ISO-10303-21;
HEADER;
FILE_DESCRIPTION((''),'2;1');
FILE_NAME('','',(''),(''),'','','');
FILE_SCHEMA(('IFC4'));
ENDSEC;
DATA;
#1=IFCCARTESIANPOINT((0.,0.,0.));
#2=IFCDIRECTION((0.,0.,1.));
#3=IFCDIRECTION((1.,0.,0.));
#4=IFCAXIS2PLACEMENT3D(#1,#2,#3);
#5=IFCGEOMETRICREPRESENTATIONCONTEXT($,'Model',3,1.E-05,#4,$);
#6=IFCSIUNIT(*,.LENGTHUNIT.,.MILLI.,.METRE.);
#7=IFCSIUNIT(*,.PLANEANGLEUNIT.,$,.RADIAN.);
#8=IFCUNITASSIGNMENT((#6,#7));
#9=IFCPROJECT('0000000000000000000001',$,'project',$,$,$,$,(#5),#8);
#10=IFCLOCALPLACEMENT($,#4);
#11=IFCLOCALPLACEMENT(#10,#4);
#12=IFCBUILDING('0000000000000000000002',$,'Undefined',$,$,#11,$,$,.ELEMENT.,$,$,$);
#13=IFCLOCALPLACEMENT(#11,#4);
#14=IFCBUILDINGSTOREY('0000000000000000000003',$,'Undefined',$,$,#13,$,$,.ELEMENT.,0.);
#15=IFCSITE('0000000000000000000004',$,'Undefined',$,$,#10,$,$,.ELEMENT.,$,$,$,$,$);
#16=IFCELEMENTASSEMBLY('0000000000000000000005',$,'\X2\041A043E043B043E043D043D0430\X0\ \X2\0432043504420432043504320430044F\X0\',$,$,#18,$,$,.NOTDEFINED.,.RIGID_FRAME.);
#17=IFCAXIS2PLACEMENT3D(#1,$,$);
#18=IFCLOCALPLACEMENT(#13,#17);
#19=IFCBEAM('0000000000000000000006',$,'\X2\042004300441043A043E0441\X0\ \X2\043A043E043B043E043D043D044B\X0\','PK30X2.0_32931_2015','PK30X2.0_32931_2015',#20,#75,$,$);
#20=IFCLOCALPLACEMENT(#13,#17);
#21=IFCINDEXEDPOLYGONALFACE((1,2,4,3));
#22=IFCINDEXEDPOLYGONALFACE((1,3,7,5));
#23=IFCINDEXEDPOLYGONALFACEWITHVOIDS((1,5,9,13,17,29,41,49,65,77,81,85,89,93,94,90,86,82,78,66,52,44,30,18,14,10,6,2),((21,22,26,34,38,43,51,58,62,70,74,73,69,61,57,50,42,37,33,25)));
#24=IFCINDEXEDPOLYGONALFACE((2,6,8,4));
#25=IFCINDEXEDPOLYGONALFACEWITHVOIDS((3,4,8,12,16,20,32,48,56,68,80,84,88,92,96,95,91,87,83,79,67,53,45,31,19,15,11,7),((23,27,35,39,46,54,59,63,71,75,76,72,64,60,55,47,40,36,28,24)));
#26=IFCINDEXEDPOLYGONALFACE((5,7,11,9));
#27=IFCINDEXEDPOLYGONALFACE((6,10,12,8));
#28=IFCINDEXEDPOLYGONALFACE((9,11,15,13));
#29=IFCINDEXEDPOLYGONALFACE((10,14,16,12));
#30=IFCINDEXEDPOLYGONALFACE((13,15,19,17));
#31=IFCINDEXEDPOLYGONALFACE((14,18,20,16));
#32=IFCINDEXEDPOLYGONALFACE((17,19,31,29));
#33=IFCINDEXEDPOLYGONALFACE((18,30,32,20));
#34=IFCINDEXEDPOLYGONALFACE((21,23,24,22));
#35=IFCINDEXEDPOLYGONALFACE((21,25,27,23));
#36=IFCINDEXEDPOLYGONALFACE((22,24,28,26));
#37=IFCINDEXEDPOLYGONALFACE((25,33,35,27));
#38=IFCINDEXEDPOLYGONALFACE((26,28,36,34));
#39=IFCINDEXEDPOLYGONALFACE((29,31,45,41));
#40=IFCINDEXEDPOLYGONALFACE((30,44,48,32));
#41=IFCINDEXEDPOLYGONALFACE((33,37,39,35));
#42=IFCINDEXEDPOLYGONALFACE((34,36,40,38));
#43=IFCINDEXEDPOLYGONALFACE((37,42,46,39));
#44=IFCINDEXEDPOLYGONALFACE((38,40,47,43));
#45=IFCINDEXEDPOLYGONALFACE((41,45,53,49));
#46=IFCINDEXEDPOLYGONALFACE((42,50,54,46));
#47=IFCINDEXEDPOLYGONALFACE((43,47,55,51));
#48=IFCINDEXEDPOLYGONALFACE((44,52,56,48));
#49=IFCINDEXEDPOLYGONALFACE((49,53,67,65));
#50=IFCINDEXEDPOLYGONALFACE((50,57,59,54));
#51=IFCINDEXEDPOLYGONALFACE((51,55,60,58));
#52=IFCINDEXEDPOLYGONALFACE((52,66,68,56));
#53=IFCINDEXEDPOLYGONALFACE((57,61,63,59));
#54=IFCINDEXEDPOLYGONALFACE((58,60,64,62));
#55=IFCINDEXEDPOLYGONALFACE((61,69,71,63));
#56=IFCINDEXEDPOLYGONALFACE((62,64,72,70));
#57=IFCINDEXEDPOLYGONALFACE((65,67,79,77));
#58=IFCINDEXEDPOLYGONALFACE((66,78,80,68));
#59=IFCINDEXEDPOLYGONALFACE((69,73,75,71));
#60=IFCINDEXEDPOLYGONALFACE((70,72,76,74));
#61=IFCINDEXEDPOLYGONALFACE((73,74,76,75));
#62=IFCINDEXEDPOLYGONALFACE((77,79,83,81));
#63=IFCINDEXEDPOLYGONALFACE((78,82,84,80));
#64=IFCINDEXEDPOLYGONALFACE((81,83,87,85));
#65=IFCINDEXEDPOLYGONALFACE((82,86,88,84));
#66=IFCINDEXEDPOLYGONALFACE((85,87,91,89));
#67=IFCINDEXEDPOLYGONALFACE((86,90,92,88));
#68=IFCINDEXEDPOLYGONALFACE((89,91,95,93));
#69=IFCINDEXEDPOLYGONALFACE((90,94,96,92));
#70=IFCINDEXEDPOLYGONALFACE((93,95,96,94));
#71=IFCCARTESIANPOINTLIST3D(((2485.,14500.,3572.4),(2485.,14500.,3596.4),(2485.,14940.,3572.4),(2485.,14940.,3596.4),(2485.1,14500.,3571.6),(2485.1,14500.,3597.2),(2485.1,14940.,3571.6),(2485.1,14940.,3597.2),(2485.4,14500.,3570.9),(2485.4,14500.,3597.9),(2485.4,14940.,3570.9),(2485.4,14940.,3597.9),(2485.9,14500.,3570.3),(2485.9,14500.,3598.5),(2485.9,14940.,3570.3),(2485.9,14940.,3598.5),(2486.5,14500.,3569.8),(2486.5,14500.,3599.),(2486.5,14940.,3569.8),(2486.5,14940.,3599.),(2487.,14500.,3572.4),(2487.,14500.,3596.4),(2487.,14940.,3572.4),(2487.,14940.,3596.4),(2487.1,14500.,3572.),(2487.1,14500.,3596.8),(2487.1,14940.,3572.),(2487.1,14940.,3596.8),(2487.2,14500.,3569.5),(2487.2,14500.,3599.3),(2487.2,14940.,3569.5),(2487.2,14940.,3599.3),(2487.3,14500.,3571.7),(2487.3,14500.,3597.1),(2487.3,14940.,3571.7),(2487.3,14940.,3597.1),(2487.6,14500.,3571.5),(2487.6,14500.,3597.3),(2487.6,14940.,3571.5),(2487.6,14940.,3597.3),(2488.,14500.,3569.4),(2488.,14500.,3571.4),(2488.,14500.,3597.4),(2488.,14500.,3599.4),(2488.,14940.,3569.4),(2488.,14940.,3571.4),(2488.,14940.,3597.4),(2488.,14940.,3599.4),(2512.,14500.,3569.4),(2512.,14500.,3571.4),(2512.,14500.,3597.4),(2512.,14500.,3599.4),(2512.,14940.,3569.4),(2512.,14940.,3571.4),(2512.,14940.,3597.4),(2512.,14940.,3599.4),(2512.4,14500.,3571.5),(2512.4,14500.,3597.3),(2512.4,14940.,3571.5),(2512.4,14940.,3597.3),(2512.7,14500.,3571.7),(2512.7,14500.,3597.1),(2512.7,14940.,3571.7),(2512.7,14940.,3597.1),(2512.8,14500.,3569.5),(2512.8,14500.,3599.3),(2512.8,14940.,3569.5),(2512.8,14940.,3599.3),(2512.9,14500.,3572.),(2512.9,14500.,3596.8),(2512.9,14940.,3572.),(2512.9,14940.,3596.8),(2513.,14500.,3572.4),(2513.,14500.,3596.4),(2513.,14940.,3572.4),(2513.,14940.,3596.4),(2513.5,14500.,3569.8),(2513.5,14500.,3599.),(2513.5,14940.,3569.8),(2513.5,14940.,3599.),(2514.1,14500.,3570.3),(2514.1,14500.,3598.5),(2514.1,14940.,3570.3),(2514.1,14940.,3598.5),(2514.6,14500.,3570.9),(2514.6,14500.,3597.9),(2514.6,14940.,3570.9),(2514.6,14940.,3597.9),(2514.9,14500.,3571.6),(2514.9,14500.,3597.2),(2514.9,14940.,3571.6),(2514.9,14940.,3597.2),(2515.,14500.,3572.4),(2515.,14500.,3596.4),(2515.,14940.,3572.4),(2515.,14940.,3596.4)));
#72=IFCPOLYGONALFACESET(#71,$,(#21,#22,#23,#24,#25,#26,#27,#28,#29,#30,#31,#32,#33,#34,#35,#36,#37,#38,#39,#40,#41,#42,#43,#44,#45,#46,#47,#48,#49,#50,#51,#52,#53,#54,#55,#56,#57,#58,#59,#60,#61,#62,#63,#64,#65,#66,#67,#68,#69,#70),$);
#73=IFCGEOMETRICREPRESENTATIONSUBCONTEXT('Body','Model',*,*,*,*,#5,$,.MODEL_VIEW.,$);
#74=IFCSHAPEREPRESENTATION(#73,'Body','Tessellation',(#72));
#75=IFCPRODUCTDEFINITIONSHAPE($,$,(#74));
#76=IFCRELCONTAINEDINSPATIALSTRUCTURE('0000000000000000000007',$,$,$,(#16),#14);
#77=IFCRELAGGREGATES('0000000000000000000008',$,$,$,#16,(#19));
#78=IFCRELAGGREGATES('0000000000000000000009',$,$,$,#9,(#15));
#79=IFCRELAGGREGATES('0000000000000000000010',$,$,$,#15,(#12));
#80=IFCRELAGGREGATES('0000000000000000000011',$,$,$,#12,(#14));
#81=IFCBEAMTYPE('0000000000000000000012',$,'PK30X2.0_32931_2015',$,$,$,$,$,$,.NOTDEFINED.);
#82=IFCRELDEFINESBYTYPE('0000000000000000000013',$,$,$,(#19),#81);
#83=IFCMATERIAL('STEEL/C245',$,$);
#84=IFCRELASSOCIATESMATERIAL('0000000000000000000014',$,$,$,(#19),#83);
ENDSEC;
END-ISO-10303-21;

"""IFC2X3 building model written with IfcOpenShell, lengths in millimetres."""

from ifc_helpers import new_model, si_unit, frame, origin_with_axes, origin_2d_with_axis, place, context, subcontext, project, spatial, hollow_rectangle, extrude, material, type_object, element, aggregate, save


model = new_model("IFC2X3")

# Units and contexts
model_context = context("Model", 3, precision=1e-05, world=origin_with_axes())
body_context = subcontext(model_context, "Body", "Model", "MODEL_VIEW")
ifc_project = project(units=[si_unit("LENGTHUNIT", "METRE", prefix="MILLI"), si_unit("PLANEANGLEUNIT", "RADIAN")], contexts=[model_context])

# Site, building, storey
site_placement = place(None, origin_with_axes())
site = spatial("IfcSite", under=ifc_project, at=site_placement, Name="Undefined", CompositionType="ELEMENT")
building_placement = place(site_placement, origin_with_axes())
building = spatial("IfcBuilding", under=site, at=building_placement, Name="Undefined", CompositionType="ELEMENT")
storey_placement = place(building_placement, origin_with_axes())
storey = spatial("IfcBuildingStorey", under=building, at=storey_placement, Name="Undefined", CompositionType="ELEMENT", Elevation=0.0)

# Shared definitions
ifc_material_1 = material(Name="STEEL/C245")

# Element assembly
assembly_1_placement = place(storey_placement, origin_with_axes())
assembly_1 = element("IfcElementAssembly", 1, at=assembly_1_placement, inside=storey, Name="Колонна ветвевая", AssemblyPlace="NOTDEFINED", PredefinedType="RIGID_FRAME")

# Beam
beam_type_1 = type_object("IfcBeamType", Name="PK30X2.0_32931_2015", PredefinedType="NOTDEFINED")
beam_1_placement = place(assembly_1_placement, frame((2500.0, 14500.0, 3584.4), z_axis=(0.0, 0.0, -1.0), x_axis=(0.0, 1.0, 0.0)))
beam_1 = element("IfcBeam", 2, at=beam_1_placement, type_object=beam_type_1, material=ifc_material_1, Name="Раскос колонны", Description="PK30X2.0_32931_2015", ObjectType="PK30X2.0_32931_2015", context=body_context, shape_type="SweptSolid", body=[
    extrude(hollow_rectangle(XDim=30.0, YDim=30.0, WallThickness=2.0, InnerFilletRadius=1.0, OuterFilletRadius=3.0, at=origin_2d_with_axis()), frame((440.0, 0.0, 0.0), z_axis=(-1.0, 0.0, 0.0), x_axis=(0.0, -1.0, 0.0)), (0.0, 0.0, 1.0), 440.0),
])
aggregate(assembly_1, [beam_1])

save(model, "model.ifc")
